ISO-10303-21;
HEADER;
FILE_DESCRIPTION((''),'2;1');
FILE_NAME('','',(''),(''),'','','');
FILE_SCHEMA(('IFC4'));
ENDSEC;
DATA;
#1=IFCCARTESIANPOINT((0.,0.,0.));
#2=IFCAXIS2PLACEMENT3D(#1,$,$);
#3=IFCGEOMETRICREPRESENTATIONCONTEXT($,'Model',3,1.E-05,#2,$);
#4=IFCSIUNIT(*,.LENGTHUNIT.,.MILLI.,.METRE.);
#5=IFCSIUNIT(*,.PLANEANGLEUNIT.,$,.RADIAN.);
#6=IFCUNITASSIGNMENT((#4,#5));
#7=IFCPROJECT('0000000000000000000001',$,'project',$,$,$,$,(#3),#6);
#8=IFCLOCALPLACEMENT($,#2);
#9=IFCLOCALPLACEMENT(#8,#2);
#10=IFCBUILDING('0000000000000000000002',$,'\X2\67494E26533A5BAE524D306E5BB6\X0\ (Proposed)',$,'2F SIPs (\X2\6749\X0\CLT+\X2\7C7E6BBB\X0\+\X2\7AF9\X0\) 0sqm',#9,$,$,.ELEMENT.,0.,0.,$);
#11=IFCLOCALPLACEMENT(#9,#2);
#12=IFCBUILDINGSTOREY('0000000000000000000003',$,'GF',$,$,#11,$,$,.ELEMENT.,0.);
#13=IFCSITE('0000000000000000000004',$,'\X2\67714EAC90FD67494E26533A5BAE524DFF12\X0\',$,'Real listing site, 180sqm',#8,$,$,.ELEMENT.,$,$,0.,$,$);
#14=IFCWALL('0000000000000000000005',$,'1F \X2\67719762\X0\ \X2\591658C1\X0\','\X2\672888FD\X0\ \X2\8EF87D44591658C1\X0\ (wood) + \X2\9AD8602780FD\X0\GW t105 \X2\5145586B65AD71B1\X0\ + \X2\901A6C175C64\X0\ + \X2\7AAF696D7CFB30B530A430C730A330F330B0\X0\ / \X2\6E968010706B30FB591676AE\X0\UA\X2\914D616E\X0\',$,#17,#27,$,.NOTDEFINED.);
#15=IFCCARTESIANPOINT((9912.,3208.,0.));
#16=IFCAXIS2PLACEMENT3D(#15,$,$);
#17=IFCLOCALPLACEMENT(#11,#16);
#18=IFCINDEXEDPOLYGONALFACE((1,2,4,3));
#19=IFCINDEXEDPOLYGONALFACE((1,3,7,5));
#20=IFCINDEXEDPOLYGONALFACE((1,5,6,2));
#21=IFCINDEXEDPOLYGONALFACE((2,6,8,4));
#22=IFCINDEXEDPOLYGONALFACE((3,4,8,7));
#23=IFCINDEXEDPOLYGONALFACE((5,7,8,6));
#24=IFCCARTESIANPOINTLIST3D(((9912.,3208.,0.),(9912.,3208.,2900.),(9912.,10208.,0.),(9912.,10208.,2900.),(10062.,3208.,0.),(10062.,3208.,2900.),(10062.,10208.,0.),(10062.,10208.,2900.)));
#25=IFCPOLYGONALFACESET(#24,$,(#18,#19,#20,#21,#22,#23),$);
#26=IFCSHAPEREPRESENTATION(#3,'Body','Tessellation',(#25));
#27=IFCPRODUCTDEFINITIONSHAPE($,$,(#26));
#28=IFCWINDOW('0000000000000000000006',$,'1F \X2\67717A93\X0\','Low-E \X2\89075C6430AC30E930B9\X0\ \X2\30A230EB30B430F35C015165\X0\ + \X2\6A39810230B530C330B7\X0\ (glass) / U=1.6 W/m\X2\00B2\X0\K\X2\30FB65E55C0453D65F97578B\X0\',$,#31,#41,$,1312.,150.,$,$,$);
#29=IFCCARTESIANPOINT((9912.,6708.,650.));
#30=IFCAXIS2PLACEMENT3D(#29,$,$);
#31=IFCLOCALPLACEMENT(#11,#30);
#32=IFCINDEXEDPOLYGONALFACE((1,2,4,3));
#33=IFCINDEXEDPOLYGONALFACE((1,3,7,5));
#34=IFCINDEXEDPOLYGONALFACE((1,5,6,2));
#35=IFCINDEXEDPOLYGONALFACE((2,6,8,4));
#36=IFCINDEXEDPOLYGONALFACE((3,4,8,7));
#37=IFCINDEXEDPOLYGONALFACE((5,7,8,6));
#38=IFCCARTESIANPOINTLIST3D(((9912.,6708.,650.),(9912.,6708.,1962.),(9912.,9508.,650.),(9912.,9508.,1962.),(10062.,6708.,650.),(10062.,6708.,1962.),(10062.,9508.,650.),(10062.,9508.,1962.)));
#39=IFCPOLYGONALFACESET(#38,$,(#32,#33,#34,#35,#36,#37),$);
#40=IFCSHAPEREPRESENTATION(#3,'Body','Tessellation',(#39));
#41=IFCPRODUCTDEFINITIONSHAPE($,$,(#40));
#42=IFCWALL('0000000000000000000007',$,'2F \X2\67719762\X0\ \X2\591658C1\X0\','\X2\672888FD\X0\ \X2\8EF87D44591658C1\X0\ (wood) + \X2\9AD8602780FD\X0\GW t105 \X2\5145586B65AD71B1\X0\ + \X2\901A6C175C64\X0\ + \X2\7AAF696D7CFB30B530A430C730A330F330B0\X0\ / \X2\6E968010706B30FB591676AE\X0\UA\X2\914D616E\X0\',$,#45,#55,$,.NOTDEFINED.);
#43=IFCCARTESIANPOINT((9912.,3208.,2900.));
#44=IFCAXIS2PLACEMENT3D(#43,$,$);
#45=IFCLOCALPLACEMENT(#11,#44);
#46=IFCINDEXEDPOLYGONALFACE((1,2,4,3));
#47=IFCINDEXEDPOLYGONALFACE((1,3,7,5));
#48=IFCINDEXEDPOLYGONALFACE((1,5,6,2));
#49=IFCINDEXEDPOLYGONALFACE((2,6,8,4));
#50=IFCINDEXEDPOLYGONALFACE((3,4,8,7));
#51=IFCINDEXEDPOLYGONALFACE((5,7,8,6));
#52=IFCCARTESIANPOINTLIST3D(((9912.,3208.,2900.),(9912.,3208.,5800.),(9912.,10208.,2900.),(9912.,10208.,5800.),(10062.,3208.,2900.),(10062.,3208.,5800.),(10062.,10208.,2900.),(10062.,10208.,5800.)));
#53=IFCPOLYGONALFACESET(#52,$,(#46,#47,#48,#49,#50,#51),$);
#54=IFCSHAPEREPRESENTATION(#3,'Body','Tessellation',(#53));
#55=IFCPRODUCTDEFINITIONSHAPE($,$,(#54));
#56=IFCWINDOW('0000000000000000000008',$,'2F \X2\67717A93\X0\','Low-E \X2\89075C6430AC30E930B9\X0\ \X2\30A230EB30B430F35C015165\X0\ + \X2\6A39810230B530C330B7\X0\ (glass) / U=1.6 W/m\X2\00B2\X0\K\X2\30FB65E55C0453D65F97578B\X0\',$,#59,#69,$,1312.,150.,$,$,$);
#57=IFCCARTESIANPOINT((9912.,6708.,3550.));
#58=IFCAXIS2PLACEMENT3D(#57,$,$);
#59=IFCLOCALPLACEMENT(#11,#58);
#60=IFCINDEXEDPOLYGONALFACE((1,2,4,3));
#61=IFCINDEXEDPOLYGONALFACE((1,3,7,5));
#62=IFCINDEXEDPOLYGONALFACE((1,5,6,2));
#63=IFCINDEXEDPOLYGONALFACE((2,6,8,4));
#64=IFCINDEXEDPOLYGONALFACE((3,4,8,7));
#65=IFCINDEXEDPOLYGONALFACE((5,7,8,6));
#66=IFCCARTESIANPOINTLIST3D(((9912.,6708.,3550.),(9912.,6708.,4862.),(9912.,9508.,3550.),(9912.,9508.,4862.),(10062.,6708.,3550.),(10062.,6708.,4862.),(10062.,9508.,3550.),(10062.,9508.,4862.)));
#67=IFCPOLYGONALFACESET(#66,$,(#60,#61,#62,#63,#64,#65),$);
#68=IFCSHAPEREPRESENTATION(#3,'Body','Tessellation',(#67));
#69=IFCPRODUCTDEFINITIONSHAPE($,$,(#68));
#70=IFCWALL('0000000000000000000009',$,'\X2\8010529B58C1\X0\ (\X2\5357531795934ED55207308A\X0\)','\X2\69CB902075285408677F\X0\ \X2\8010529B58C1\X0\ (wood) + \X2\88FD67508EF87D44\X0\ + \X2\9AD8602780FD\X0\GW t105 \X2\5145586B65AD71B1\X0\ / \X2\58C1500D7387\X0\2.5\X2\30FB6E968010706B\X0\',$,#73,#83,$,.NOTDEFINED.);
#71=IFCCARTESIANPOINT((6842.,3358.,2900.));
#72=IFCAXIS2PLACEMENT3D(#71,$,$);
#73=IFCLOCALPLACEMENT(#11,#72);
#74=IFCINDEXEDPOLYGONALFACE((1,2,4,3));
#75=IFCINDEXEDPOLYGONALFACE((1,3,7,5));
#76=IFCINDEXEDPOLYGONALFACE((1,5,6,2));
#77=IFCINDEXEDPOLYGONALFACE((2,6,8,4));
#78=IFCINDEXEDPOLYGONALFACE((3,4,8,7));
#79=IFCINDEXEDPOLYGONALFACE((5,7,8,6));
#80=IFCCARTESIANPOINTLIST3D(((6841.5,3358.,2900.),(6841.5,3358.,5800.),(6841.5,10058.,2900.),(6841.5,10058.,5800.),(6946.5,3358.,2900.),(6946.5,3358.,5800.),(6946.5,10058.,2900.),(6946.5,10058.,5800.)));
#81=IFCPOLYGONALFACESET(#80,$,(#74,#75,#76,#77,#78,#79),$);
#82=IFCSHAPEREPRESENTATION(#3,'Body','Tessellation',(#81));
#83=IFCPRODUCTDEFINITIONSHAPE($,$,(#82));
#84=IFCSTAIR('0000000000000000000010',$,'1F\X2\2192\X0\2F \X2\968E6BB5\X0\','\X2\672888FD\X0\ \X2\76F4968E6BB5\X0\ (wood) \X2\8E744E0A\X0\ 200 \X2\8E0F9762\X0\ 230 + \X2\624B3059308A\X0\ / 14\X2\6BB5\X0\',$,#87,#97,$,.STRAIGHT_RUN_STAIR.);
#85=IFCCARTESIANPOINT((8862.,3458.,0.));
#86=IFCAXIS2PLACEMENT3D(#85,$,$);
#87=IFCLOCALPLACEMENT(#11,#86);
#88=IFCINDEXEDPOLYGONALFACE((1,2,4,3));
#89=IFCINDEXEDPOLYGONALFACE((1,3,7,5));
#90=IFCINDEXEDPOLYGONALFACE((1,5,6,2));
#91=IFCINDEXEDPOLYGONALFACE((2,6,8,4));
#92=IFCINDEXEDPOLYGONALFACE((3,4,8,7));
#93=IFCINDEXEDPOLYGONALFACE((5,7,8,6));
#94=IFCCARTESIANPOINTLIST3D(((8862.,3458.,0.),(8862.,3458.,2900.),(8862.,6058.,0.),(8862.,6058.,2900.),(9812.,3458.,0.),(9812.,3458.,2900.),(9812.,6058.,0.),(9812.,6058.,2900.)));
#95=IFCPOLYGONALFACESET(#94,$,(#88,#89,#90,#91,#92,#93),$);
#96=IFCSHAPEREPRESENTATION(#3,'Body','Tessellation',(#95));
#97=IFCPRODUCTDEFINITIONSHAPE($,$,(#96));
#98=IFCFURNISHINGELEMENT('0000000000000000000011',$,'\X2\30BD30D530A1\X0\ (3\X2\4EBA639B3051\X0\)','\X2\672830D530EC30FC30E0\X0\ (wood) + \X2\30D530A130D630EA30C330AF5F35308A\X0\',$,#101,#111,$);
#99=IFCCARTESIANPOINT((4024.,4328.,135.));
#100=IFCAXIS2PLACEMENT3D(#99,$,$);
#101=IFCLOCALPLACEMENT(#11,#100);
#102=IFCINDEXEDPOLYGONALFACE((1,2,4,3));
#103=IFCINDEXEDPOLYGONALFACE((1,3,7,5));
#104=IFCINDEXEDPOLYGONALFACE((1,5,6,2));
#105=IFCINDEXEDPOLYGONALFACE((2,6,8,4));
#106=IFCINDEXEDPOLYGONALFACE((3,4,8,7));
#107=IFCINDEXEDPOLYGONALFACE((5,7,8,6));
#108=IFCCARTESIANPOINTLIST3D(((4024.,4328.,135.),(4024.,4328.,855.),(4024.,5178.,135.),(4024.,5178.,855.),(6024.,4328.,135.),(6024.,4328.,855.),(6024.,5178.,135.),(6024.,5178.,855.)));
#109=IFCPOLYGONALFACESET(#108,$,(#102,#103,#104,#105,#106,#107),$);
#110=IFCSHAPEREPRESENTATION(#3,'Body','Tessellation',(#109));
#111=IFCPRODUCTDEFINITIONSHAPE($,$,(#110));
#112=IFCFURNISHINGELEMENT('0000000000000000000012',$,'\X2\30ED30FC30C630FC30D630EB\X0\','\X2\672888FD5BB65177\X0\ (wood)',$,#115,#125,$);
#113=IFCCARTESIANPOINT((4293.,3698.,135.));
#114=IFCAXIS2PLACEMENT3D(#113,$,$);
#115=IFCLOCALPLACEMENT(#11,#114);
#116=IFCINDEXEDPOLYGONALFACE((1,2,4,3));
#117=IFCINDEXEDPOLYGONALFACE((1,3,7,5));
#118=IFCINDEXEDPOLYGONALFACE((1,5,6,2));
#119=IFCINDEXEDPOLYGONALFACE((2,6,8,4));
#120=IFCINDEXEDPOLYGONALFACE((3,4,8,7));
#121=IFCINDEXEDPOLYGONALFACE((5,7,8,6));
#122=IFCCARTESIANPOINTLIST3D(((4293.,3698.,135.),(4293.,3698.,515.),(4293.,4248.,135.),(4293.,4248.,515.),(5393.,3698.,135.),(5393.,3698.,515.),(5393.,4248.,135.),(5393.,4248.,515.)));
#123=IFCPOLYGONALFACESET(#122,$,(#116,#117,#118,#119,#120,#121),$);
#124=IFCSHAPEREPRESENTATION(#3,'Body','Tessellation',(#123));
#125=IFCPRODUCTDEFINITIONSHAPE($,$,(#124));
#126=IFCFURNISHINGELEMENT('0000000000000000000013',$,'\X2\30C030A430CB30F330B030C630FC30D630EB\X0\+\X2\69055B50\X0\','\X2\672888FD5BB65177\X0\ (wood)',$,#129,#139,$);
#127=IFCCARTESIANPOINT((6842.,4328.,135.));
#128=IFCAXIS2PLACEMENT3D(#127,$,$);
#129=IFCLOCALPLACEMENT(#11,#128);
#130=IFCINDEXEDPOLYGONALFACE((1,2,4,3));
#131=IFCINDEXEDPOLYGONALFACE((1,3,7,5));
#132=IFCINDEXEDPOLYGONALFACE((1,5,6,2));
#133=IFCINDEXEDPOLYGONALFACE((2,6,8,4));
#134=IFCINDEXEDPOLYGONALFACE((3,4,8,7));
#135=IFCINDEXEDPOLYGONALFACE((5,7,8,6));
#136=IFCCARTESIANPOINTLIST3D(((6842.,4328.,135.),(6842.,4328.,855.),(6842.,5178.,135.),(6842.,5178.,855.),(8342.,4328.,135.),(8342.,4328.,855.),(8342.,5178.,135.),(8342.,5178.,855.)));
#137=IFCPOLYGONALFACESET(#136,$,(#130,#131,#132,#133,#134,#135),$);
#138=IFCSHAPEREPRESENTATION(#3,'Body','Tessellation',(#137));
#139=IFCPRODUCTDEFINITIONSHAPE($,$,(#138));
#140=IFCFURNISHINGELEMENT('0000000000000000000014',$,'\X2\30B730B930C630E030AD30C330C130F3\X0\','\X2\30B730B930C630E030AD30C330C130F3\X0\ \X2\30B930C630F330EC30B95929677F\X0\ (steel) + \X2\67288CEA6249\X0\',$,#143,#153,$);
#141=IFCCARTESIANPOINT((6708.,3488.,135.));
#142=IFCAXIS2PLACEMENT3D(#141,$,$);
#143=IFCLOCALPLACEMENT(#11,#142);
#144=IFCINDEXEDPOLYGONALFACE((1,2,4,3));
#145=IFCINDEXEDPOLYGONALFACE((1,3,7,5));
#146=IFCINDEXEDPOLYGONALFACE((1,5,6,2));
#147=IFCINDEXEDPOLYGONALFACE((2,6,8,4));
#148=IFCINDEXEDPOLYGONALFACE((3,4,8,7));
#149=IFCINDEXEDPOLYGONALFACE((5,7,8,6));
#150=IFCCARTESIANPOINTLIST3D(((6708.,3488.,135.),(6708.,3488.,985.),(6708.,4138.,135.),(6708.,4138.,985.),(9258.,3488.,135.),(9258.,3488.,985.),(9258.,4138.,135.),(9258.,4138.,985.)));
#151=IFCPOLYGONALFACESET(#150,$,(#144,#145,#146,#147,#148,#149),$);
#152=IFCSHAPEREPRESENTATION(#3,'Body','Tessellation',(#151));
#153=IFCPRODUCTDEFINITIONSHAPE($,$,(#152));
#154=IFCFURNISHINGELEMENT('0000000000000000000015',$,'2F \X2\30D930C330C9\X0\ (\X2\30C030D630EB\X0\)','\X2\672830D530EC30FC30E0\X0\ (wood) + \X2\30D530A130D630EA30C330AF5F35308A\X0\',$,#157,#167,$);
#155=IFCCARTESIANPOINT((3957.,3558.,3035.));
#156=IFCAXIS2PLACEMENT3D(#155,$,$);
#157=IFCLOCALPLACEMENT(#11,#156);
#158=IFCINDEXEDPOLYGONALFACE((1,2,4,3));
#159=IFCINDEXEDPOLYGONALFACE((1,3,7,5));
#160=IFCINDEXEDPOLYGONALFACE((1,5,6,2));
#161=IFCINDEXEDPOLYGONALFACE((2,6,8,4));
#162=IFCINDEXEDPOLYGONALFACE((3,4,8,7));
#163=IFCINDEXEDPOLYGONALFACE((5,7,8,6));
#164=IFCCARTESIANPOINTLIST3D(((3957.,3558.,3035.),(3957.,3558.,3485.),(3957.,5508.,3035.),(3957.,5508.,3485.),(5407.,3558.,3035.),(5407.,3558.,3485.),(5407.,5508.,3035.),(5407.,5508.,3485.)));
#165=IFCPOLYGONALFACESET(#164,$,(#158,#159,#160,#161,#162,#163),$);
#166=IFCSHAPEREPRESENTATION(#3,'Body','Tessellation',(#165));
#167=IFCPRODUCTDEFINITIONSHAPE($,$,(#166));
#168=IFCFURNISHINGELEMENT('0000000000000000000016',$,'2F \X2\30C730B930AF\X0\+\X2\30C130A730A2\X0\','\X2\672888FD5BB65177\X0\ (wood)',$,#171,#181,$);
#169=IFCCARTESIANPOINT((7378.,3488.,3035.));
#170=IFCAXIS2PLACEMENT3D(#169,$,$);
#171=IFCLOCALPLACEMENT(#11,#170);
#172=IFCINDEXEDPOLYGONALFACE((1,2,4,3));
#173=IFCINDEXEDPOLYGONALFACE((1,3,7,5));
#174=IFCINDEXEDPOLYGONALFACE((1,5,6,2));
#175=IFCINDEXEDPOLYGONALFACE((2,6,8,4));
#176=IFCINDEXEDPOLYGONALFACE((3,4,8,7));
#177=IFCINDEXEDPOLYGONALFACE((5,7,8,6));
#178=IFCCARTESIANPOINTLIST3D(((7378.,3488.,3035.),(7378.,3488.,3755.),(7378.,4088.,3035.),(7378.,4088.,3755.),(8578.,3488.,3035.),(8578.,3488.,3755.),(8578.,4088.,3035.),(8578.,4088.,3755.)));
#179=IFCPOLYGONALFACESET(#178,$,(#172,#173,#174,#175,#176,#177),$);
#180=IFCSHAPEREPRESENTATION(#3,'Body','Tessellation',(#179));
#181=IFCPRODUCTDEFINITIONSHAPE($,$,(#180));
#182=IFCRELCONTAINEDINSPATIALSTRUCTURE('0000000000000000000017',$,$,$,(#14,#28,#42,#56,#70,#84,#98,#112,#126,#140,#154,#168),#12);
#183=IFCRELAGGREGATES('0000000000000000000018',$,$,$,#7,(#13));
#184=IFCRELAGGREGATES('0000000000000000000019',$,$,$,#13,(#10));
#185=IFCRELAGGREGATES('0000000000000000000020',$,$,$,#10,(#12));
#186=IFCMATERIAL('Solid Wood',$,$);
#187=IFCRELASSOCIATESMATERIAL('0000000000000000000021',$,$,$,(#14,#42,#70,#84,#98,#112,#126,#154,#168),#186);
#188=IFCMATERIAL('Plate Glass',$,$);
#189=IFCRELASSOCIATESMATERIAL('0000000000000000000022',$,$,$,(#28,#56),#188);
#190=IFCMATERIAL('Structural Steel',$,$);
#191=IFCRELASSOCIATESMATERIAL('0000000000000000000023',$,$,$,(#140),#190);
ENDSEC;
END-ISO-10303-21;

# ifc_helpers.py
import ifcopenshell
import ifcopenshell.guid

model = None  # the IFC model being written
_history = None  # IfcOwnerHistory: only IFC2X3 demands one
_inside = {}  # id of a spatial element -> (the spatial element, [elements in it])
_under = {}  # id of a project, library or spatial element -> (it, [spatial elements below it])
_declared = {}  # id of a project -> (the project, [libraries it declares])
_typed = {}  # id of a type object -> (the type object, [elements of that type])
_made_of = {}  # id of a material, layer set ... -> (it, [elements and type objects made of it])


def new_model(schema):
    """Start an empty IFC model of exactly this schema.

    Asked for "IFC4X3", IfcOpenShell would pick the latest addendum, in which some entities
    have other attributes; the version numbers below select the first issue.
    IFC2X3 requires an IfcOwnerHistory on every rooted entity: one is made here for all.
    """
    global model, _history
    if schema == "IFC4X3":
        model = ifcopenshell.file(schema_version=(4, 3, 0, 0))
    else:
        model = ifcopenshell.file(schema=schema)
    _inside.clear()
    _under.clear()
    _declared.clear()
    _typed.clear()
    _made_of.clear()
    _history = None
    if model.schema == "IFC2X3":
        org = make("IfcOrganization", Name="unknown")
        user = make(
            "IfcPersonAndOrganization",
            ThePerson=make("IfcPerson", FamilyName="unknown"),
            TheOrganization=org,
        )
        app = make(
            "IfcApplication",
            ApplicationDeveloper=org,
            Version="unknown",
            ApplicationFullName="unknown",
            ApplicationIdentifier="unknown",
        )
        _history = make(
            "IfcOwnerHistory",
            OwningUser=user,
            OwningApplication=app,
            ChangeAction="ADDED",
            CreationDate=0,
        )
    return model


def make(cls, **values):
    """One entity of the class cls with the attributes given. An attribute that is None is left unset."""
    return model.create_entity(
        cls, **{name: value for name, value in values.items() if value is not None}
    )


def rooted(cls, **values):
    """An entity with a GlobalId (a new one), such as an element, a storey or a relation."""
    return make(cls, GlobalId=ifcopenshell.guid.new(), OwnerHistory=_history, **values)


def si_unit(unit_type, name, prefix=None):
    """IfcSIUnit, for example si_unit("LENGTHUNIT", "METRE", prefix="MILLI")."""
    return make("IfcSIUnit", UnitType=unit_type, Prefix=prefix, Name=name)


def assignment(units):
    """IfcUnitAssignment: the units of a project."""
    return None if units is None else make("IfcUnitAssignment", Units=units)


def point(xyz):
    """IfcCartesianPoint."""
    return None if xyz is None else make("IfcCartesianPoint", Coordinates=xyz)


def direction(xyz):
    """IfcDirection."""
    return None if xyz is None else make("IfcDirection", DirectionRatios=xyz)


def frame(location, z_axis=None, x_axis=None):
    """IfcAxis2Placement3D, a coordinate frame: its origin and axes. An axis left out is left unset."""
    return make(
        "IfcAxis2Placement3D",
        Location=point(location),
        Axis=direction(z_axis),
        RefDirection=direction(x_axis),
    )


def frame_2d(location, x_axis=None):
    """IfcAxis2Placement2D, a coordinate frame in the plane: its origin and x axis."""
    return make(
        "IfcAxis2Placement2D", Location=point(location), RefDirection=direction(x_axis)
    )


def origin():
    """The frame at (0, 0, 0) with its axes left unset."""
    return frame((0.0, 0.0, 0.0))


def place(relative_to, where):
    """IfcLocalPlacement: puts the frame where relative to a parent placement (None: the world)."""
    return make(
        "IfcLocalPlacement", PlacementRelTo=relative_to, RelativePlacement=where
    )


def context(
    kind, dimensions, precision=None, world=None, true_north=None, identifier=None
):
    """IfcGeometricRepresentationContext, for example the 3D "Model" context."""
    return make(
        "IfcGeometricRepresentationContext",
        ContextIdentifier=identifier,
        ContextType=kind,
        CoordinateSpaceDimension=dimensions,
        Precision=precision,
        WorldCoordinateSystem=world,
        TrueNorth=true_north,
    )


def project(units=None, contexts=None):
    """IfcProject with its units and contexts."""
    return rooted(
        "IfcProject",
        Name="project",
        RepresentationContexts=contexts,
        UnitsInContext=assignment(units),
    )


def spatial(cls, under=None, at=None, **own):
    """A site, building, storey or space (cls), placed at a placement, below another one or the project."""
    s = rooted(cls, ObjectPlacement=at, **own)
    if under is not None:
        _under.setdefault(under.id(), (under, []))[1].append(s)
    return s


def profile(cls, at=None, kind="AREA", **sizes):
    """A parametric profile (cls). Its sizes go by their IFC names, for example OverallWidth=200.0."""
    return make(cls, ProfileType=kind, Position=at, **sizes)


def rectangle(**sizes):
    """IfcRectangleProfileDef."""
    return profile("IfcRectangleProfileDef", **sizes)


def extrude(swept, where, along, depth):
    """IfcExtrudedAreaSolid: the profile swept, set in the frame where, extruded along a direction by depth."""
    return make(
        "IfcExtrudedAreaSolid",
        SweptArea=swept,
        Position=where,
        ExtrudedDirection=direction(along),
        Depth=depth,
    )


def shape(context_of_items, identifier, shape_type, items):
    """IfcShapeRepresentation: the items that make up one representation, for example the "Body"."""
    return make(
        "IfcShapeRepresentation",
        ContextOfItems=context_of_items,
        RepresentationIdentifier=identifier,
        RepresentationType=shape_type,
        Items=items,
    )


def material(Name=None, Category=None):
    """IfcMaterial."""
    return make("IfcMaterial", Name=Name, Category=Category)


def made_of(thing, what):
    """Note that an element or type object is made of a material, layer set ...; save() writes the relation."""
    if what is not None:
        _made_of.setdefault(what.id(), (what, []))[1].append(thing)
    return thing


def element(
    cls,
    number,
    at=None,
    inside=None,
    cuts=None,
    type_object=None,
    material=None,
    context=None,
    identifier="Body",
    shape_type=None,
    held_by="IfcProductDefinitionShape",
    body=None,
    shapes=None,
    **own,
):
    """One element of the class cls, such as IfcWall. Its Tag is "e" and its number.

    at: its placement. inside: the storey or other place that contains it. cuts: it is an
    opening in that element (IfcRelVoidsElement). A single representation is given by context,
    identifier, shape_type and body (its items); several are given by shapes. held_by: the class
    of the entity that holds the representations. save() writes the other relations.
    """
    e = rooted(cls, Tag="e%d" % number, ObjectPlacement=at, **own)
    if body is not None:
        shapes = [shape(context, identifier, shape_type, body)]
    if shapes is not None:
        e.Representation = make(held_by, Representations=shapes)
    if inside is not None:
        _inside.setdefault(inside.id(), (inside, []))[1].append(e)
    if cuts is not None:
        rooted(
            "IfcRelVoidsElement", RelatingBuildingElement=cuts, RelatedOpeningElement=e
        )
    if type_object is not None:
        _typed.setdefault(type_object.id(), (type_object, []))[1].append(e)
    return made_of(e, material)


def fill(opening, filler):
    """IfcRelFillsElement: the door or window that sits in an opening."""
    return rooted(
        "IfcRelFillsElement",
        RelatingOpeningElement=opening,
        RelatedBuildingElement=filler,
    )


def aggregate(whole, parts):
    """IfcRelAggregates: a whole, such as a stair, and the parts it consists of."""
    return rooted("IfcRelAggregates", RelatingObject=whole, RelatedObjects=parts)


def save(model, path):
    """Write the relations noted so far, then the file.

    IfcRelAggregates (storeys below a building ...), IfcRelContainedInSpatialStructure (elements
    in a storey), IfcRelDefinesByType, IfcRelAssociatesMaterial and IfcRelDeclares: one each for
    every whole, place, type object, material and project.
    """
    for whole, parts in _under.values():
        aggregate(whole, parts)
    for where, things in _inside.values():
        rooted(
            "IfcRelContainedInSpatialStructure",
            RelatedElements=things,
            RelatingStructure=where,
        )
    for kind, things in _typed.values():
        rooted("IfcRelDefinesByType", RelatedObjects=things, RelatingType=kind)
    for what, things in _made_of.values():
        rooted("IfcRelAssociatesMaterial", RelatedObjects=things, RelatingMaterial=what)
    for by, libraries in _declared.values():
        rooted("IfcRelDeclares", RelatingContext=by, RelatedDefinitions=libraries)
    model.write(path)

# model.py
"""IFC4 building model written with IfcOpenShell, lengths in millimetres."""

from ifc_helpers import new_model, si_unit, frame, frame_2d, origin, place, context, project, spatial, rectangle, extrude, material, element, fill, save


model = new_model("IFC4")

# Units and contexts
model_context = context("Model", 3, precision=1e-05, world=origin())
ifc_project = project(units=[si_unit("LENGTHUNIT", "METRE", prefix="MILLI"), si_unit("PLANEANGLEUNIT", "RADIAN")], contexts=[model_context])

# Site, building, storey
site_placement = place(None, origin())
site = spatial("IfcSite", under=ifc_project, at=site_placement, Name="東京都杉並区宮前２", ObjectType="Real listing site, 180sqm", CompositionType="ELEMENT", RefElevation=0.0)
building_placement = place(site_placement, origin())
building = spatial("IfcBuilding", under=site, at=building_placement, Name="杉並区宮前の家 (Proposed)", ObjectType="2F SIPs (杉CLT+籾殻+竹) 0sqm", CompositionType="ELEMENT", ElevationOfRefHeight=0.0, ElevationOfTerrain=0.0)
storey_placement = place(building_placement, origin())
storey = spatial("IfcBuildingStorey", under=building, at=storey_placement, Name="GF", CompositionType="ELEMENT", Elevation=0.0)

# Wall, opening, window
ifc_material_1 = material(Name="Solid Wood")
wall_1_placement = place(storey_placement, frame((9912.0, 3208.0, 0.0)))
wall_1 = element("IfcWall", 1, at=wall_1_placement, inside=storey, material=ifc_material_1, Name="1F 東面 外壁", Description="木製 軸組外壁 (wood) + 高性能GW t105 充填断熱 + 通気層 + 窯業系サイディング / 準耐火・外皮UA配慮", PredefinedType="NOTDEFINED", context=model_context, shape_type="SweptSolid", body=[
    extrude(rectangle(XDim=150.0, YDim=7000.0, at=frame_2d((75.0, 3500.0))), frame((9912.0, 3208.0, 0.0)), (0.0, 0.0, 1.0), 2900.0),
])
opening_1_placement = place(storey_placement, frame((9912.0, 6708.0, 650.0)))
opening_1 = element("IfcOpeningElement", 2, at=opening_1_placement, cuts=wall_1, PredefinedType="NOTDEFINED", context=model_context, shape_type="SweptSolid", body=[
    extrude(rectangle(XDim=150.0, YDim=2800.0, at=frame_2d((75.0, 1400.0))), frame((9912.0, 6708.0, 650.0)), (0.0, 0.0, 1.0), 1312.0),
])
ifc_material_2 = material(Name="Plate Glass")
window_1_placement = place(storey_placement, frame((9912.0, 6708.0, 650.0)))
window_1 = element("IfcWindow", 3, at=window_1_placement, inside=storey, material=ifc_material_2, Name="1F 東窓", Description="Low-E 複層ガラス アルゴン封入 + 樹脂サッシ (glass) / U=1.6 W/m²K・日射取得型", OverallHeight=1312.0, OverallWidth=150.0, context=model_context, shape_type="SweptSolid", body=[
    extrude(rectangle(XDim=150.0, YDim=2800.0, at=frame_2d((75.0, 1400.0))), frame((9912.0, 6708.0, 650.0)), (0.0, 0.0, 1.0), 1312.0),
])
fill(opening_1, window_1)

# Wall, opening, window
wall_2_placement = place(storey_placement, frame((9912.0, 3208.0, 2900.0)))
wall_2 = element("IfcWall", 4, at=wall_2_placement, inside=storey, material=ifc_material_1, Name="2F 東面 外壁", Description="木製 軸組外壁 (wood) + 高性能GW t105 充填断熱 + 通気層 + 窯業系サイディング / 準耐火・外皮UA配慮", PredefinedType="NOTDEFINED", context=model_context, shape_type="SweptSolid", body=[
    extrude(rectangle(XDim=150.0, YDim=7000.0, at=frame_2d((75.0, 3500.0))), frame((9912.0, 3208.0, 2900.0)), (0.0, 0.0, 1.0), 2900.0),
])
opening_2_placement = place(storey_placement, frame((9912.0, 6708.0, 3550.0)))
opening_2 = element("IfcOpeningElement", 5, at=opening_2_placement, cuts=wall_2, PredefinedType="NOTDEFINED", context=model_context, shape_type="SweptSolid", body=[
    extrude(rectangle(XDim=150.0, YDim=2800.0, at=frame_2d((75.0, 1400.0))), frame((9912.0, 6708.0, 3550.0)), (0.0, 0.0, 1.0), 1312.0),
])
window_2_placement = place(storey_placement, frame((9912.0, 6708.0, 3550.0)))
window_2 = element("IfcWindow", 6, at=window_2_placement, inside=storey, material=ifc_material_2, Name="2F 東窓", Description="Low-E 複層ガラス アルゴン封入 + 樹脂サッシ (glass) / U=1.6 W/m²K・日射取得型", OverallHeight=1312.0, OverallWidth=150.0, context=model_context, shape_type="SweptSolid", body=[
    extrude(rectangle(XDim=150.0, YDim=2800.0, at=frame_2d((75.0, 1400.0))), frame((9912.0, 6708.0, 3550.0)), (0.0, 0.0, 1.0), 1312.0),
])
fill(opening_2, window_2)

# Wall
wall_3_placement = place(storey_placement, frame((6842.0, 3358.0, 2900.0)))
element("IfcWall", 7, at=wall_3_placement, inside=storey, material=ifc_material_1, Name="耐力壁 (南北間仕切り)", Description="構造用合板 耐力壁 (wood) + 製材軸組 + 高性能GW t105 充填断熱 / 壁倍率2.5・準耐火", PredefinedType="NOTDEFINED", context=model_context, shape_type="SweptSolid", body=[
    extrude(rectangle(XDim=105.0, YDim=6700.0, at=frame_2d((52.0, 3350.0))), frame((6842.0, 3358.0, 2900.0)), (0.0, 0.0, 1.0), 2900.0),
])

# Stair
stair_placement = place(storey_placement, frame((8862.0, 3458.0, 0.0)))
element("IfcStair", 8, at=stair_placement, inside=storey, material=ifc_material_1, Name="1F→2F 階段", Description="木製 直階段 (wood) 蹴上 200 踏面 230 + 手すり / 14段", PredefinedType="STRAIGHT_RUN_STAIR", context=model_context, shape_type="SweptSolid", body=[
    extrude(rectangle(XDim=950.0, YDim=2600.0, at=frame_2d((475.0, 1300.0))), frame((8862.0, 3458.0, 0.0)), (0.0, 0.0, 1.0), 2900.0),
])

# Furnishing elements
furnishing_1_placement = place(storey_placement, frame((4024.0, 4328.0, 135.0)))
element("IfcFurnishingElement", 9, at=furnishing_1_placement, inside=storey, material=ifc_material_1, Name="ソファ (3人掛け)", Description="木フレーム (wood) + ファブリック張り", context=model_context, shape_type="SweptSolid", body=[
    extrude(rectangle(XDim=2000.0, YDim=850.0, at=frame_2d((1000.0, 425.0))), frame((4024.0, 4328.0, 135.0)), (0.0, 0.0, 1.0), 720.0),
])
furnishing_2_placement = place(storey_placement, frame((4293.0, 3698.0, 135.0)))
element("IfcFurnishingElement", 10, at=furnishing_2_placement, inside=storey, material=ifc_material_1, Name="ローテーブル", Description="木製家具 (wood)", context=model_context, shape_type="SweptSolid", body=[
    extrude(rectangle(XDim=1100.0, YDim=550.0, at=frame_2d((550.0, 275.0))), frame((4293.0, 3698.0, 135.0)), (0.0, 0.0, 1.0), 380.0),
])
furnishing_3_placement = place(storey_placement, frame((6842.0, 4328.0, 135.0)))
element("IfcFurnishingElement", 11, at=furnishing_3_placement, inside=storey, material=ifc_material_1, Name="ダイニングテーブル+椅子", Description="木製家具 (wood)", context=model_context, shape_type="SweptSolid", body=[
    extrude(rectangle(XDim=1500.0, YDim=850.0, at=frame_2d((750.0, 425.0))), frame((6842.0, 4328.0, 135.0)), (0.0, 0.0, 1.0), 720.0),
])
ifc_material_3 = material(Name="Structural Steel")
furnishing_4_placement = place(storey_placement, frame((6708.0, 3488.0, 135.0)))
element("IfcFurnishingElement", 12, at=furnishing_4_placement, inside=storey, material=ifc_material_3, Name="システムキッチン", Description="システムキッチン ステンレス天板 (steel) + 木質扉", context=model_context, shape_type="SweptSolid", body=[
    extrude(rectangle(XDim=2550.0, YDim=650.0, at=frame_2d((1275.0, 325.0))), frame((6708.0, 3488.0, 135.0)), (0.0, 0.0, 1.0), 850.0),
])
furnishing_5_placement = place(storey_placement, frame((3957.0, 3558.0, 3035.0)))
element("IfcFurnishingElement", 13, at=furnishing_5_placement, inside=storey, material=ifc_material_1, Name="2F ベッド (ダブル)", Description="木フレーム (wood) + ファブリック張り", context=model_context, shape_type="SweptSolid", body=[
    extrude(rectangle(XDim=1450.0, YDim=1950.0, at=frame_2d((725.0, 975.0))), frame((3957.0, 3558.0, 3035.0)), (0.0, 0.0, 1.0), 450.0),
])
furnishing_6_placement = place(storey_placement, frame((7378.0, 3488.0, 3035.0)))
element("IfcFurnishingElement", 14, at=furnishing_6_placement, inside=storey, material=ifc_material_1, Name="2F デスク+チェア", Description="木製家具 (wood)", context=model_context, shape_type="SweptSolid", body=[
    extrude(rectangle(XDim=1200.0, YDim=600.0, at=frame_2d((600.0, 300.0))), frame((7378.0, 3488.0, 3035.0)), (0.0, 0.0, 1.0), 720.0),
])

save(model, "model.ifc")
